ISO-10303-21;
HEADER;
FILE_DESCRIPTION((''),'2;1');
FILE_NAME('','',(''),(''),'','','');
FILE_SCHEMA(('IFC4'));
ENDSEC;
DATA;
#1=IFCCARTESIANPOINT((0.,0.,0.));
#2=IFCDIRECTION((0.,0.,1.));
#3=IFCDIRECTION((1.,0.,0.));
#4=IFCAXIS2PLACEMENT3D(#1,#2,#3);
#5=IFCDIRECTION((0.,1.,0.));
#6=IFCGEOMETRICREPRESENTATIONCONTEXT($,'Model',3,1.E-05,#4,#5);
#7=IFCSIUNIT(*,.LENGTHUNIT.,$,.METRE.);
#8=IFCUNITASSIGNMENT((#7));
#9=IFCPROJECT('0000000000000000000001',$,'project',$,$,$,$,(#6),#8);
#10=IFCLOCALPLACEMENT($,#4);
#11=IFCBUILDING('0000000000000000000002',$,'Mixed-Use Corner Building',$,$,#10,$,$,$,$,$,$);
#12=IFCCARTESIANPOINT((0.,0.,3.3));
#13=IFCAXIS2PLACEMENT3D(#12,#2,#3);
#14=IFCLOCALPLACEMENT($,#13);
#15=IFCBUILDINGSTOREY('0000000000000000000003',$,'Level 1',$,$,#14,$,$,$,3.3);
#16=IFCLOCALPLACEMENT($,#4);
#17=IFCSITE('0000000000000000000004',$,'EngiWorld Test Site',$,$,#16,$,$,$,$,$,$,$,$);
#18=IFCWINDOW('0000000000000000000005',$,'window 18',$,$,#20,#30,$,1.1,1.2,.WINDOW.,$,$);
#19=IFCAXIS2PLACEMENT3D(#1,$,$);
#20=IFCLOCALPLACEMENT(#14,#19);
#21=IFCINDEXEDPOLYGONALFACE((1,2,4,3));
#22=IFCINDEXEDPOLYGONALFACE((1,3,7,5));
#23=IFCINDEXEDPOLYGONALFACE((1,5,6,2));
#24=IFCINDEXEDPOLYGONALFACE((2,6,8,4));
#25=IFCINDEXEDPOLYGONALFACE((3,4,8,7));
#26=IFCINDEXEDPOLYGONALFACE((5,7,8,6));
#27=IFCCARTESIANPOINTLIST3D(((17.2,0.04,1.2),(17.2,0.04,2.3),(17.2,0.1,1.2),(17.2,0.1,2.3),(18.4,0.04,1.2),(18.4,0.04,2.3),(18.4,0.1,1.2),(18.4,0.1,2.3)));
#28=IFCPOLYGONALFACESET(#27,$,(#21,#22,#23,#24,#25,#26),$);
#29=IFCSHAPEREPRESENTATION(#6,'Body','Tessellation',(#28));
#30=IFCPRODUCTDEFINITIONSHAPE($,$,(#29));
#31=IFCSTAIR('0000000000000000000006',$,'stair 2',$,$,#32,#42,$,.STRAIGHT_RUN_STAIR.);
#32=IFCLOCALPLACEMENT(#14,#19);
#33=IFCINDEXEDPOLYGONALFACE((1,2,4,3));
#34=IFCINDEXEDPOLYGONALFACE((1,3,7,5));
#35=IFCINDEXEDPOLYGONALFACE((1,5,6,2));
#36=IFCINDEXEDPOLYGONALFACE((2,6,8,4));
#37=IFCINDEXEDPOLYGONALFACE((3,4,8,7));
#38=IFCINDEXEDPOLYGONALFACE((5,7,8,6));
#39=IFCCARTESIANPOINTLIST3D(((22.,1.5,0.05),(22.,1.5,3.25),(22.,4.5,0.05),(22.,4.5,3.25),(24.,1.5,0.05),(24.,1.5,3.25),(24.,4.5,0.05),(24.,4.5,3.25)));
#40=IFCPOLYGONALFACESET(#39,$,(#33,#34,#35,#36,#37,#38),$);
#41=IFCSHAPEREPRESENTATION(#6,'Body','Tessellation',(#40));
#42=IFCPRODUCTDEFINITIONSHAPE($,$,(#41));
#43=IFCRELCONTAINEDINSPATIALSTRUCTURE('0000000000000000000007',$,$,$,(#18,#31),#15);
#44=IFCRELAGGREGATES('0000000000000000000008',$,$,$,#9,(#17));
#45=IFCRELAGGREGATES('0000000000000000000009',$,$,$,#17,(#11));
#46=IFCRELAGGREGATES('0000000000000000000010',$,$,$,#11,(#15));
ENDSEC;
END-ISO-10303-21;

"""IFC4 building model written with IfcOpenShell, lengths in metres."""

from ifc_helpers import new_model, si_unit, direction, frame, origin_with_axes, origin_2d_with_axis, place, context, project, spatial, rectangle, extrude, element, save


model = new_model("IFC4")

# Units and contexts
model_context = context("Model", 3, precision=1e-05, world=origin_with_axes(), true_north=direction((0.0, 1.0, 0.0)))
ifc_project = project(units=[si_unit("LENGTHUNIT", "METRE")], contexts=[model_context])

# Site, building, storey
site_placement = place(None, origin_with_axes())
site = spatial("IfcSite", under=ifc_project, at=site_placement, Name="EngiWorld Test Site")
building_placement = place(None, origin_with_axes())
building = spatial("IfcBuilding", under=site, at=building_placement, Name="Mixed-Use Corner Building")
storey_placement = place(None, frame((0.0, 0.0, 3.3), z_axis=(0.0, 0.0, 1.0), x_axis=(1.0, 0.0, 0.0)))
storey = spatial("IfcBuildingStorey", under=building, at=storey_placement, Name="Level 1", Elevation=3.3)

# Window
for number, where, z_axis, x_axis, name in (
    (1, (17.8, 0.07, 4.5), (0.0, 0.0, 1.0), (1.0, 0.0, 0.0), "window 18"),
):
    element("IfcWindow", number, at=place(None, frame(where, z_axis=z_axis, x_axis=x_axis)), inside=storey, Name=name, OverallHeight=1.1, OverallWidth=1.2, PredefinedType="WINDOW", context=model_context, shape_type="SweptSolid", body=[
        extrude(rectangle(XDim=1.2, YDim=0.06, at=origin_2d_with_axis()), origin_with_axes(), (0.0, 0.0, 1.0), 1.1),
    ])

# Stair
stair_placement = place(None, frame((23.0, 3.0, 3.35), z_axis=(0.0, 0.0, 1.0), x_axis=(1.0, 0.0, 0.0)))
element("IfcStair", 2, at=stair_placement, inside=storey, Name="stair 2", PredefinedType="STRAIGHT_RUN_STAIR", context=model_context, shape_type="SweptSolid", body=[
    extrude(rectangle(XDim=2.0, YDim=3.0, at=origin_2d_with_axis()), origin_with_axes(), (0.0, 0.0, 1.0), 3.2),
])

save(model, "model.ifc")
